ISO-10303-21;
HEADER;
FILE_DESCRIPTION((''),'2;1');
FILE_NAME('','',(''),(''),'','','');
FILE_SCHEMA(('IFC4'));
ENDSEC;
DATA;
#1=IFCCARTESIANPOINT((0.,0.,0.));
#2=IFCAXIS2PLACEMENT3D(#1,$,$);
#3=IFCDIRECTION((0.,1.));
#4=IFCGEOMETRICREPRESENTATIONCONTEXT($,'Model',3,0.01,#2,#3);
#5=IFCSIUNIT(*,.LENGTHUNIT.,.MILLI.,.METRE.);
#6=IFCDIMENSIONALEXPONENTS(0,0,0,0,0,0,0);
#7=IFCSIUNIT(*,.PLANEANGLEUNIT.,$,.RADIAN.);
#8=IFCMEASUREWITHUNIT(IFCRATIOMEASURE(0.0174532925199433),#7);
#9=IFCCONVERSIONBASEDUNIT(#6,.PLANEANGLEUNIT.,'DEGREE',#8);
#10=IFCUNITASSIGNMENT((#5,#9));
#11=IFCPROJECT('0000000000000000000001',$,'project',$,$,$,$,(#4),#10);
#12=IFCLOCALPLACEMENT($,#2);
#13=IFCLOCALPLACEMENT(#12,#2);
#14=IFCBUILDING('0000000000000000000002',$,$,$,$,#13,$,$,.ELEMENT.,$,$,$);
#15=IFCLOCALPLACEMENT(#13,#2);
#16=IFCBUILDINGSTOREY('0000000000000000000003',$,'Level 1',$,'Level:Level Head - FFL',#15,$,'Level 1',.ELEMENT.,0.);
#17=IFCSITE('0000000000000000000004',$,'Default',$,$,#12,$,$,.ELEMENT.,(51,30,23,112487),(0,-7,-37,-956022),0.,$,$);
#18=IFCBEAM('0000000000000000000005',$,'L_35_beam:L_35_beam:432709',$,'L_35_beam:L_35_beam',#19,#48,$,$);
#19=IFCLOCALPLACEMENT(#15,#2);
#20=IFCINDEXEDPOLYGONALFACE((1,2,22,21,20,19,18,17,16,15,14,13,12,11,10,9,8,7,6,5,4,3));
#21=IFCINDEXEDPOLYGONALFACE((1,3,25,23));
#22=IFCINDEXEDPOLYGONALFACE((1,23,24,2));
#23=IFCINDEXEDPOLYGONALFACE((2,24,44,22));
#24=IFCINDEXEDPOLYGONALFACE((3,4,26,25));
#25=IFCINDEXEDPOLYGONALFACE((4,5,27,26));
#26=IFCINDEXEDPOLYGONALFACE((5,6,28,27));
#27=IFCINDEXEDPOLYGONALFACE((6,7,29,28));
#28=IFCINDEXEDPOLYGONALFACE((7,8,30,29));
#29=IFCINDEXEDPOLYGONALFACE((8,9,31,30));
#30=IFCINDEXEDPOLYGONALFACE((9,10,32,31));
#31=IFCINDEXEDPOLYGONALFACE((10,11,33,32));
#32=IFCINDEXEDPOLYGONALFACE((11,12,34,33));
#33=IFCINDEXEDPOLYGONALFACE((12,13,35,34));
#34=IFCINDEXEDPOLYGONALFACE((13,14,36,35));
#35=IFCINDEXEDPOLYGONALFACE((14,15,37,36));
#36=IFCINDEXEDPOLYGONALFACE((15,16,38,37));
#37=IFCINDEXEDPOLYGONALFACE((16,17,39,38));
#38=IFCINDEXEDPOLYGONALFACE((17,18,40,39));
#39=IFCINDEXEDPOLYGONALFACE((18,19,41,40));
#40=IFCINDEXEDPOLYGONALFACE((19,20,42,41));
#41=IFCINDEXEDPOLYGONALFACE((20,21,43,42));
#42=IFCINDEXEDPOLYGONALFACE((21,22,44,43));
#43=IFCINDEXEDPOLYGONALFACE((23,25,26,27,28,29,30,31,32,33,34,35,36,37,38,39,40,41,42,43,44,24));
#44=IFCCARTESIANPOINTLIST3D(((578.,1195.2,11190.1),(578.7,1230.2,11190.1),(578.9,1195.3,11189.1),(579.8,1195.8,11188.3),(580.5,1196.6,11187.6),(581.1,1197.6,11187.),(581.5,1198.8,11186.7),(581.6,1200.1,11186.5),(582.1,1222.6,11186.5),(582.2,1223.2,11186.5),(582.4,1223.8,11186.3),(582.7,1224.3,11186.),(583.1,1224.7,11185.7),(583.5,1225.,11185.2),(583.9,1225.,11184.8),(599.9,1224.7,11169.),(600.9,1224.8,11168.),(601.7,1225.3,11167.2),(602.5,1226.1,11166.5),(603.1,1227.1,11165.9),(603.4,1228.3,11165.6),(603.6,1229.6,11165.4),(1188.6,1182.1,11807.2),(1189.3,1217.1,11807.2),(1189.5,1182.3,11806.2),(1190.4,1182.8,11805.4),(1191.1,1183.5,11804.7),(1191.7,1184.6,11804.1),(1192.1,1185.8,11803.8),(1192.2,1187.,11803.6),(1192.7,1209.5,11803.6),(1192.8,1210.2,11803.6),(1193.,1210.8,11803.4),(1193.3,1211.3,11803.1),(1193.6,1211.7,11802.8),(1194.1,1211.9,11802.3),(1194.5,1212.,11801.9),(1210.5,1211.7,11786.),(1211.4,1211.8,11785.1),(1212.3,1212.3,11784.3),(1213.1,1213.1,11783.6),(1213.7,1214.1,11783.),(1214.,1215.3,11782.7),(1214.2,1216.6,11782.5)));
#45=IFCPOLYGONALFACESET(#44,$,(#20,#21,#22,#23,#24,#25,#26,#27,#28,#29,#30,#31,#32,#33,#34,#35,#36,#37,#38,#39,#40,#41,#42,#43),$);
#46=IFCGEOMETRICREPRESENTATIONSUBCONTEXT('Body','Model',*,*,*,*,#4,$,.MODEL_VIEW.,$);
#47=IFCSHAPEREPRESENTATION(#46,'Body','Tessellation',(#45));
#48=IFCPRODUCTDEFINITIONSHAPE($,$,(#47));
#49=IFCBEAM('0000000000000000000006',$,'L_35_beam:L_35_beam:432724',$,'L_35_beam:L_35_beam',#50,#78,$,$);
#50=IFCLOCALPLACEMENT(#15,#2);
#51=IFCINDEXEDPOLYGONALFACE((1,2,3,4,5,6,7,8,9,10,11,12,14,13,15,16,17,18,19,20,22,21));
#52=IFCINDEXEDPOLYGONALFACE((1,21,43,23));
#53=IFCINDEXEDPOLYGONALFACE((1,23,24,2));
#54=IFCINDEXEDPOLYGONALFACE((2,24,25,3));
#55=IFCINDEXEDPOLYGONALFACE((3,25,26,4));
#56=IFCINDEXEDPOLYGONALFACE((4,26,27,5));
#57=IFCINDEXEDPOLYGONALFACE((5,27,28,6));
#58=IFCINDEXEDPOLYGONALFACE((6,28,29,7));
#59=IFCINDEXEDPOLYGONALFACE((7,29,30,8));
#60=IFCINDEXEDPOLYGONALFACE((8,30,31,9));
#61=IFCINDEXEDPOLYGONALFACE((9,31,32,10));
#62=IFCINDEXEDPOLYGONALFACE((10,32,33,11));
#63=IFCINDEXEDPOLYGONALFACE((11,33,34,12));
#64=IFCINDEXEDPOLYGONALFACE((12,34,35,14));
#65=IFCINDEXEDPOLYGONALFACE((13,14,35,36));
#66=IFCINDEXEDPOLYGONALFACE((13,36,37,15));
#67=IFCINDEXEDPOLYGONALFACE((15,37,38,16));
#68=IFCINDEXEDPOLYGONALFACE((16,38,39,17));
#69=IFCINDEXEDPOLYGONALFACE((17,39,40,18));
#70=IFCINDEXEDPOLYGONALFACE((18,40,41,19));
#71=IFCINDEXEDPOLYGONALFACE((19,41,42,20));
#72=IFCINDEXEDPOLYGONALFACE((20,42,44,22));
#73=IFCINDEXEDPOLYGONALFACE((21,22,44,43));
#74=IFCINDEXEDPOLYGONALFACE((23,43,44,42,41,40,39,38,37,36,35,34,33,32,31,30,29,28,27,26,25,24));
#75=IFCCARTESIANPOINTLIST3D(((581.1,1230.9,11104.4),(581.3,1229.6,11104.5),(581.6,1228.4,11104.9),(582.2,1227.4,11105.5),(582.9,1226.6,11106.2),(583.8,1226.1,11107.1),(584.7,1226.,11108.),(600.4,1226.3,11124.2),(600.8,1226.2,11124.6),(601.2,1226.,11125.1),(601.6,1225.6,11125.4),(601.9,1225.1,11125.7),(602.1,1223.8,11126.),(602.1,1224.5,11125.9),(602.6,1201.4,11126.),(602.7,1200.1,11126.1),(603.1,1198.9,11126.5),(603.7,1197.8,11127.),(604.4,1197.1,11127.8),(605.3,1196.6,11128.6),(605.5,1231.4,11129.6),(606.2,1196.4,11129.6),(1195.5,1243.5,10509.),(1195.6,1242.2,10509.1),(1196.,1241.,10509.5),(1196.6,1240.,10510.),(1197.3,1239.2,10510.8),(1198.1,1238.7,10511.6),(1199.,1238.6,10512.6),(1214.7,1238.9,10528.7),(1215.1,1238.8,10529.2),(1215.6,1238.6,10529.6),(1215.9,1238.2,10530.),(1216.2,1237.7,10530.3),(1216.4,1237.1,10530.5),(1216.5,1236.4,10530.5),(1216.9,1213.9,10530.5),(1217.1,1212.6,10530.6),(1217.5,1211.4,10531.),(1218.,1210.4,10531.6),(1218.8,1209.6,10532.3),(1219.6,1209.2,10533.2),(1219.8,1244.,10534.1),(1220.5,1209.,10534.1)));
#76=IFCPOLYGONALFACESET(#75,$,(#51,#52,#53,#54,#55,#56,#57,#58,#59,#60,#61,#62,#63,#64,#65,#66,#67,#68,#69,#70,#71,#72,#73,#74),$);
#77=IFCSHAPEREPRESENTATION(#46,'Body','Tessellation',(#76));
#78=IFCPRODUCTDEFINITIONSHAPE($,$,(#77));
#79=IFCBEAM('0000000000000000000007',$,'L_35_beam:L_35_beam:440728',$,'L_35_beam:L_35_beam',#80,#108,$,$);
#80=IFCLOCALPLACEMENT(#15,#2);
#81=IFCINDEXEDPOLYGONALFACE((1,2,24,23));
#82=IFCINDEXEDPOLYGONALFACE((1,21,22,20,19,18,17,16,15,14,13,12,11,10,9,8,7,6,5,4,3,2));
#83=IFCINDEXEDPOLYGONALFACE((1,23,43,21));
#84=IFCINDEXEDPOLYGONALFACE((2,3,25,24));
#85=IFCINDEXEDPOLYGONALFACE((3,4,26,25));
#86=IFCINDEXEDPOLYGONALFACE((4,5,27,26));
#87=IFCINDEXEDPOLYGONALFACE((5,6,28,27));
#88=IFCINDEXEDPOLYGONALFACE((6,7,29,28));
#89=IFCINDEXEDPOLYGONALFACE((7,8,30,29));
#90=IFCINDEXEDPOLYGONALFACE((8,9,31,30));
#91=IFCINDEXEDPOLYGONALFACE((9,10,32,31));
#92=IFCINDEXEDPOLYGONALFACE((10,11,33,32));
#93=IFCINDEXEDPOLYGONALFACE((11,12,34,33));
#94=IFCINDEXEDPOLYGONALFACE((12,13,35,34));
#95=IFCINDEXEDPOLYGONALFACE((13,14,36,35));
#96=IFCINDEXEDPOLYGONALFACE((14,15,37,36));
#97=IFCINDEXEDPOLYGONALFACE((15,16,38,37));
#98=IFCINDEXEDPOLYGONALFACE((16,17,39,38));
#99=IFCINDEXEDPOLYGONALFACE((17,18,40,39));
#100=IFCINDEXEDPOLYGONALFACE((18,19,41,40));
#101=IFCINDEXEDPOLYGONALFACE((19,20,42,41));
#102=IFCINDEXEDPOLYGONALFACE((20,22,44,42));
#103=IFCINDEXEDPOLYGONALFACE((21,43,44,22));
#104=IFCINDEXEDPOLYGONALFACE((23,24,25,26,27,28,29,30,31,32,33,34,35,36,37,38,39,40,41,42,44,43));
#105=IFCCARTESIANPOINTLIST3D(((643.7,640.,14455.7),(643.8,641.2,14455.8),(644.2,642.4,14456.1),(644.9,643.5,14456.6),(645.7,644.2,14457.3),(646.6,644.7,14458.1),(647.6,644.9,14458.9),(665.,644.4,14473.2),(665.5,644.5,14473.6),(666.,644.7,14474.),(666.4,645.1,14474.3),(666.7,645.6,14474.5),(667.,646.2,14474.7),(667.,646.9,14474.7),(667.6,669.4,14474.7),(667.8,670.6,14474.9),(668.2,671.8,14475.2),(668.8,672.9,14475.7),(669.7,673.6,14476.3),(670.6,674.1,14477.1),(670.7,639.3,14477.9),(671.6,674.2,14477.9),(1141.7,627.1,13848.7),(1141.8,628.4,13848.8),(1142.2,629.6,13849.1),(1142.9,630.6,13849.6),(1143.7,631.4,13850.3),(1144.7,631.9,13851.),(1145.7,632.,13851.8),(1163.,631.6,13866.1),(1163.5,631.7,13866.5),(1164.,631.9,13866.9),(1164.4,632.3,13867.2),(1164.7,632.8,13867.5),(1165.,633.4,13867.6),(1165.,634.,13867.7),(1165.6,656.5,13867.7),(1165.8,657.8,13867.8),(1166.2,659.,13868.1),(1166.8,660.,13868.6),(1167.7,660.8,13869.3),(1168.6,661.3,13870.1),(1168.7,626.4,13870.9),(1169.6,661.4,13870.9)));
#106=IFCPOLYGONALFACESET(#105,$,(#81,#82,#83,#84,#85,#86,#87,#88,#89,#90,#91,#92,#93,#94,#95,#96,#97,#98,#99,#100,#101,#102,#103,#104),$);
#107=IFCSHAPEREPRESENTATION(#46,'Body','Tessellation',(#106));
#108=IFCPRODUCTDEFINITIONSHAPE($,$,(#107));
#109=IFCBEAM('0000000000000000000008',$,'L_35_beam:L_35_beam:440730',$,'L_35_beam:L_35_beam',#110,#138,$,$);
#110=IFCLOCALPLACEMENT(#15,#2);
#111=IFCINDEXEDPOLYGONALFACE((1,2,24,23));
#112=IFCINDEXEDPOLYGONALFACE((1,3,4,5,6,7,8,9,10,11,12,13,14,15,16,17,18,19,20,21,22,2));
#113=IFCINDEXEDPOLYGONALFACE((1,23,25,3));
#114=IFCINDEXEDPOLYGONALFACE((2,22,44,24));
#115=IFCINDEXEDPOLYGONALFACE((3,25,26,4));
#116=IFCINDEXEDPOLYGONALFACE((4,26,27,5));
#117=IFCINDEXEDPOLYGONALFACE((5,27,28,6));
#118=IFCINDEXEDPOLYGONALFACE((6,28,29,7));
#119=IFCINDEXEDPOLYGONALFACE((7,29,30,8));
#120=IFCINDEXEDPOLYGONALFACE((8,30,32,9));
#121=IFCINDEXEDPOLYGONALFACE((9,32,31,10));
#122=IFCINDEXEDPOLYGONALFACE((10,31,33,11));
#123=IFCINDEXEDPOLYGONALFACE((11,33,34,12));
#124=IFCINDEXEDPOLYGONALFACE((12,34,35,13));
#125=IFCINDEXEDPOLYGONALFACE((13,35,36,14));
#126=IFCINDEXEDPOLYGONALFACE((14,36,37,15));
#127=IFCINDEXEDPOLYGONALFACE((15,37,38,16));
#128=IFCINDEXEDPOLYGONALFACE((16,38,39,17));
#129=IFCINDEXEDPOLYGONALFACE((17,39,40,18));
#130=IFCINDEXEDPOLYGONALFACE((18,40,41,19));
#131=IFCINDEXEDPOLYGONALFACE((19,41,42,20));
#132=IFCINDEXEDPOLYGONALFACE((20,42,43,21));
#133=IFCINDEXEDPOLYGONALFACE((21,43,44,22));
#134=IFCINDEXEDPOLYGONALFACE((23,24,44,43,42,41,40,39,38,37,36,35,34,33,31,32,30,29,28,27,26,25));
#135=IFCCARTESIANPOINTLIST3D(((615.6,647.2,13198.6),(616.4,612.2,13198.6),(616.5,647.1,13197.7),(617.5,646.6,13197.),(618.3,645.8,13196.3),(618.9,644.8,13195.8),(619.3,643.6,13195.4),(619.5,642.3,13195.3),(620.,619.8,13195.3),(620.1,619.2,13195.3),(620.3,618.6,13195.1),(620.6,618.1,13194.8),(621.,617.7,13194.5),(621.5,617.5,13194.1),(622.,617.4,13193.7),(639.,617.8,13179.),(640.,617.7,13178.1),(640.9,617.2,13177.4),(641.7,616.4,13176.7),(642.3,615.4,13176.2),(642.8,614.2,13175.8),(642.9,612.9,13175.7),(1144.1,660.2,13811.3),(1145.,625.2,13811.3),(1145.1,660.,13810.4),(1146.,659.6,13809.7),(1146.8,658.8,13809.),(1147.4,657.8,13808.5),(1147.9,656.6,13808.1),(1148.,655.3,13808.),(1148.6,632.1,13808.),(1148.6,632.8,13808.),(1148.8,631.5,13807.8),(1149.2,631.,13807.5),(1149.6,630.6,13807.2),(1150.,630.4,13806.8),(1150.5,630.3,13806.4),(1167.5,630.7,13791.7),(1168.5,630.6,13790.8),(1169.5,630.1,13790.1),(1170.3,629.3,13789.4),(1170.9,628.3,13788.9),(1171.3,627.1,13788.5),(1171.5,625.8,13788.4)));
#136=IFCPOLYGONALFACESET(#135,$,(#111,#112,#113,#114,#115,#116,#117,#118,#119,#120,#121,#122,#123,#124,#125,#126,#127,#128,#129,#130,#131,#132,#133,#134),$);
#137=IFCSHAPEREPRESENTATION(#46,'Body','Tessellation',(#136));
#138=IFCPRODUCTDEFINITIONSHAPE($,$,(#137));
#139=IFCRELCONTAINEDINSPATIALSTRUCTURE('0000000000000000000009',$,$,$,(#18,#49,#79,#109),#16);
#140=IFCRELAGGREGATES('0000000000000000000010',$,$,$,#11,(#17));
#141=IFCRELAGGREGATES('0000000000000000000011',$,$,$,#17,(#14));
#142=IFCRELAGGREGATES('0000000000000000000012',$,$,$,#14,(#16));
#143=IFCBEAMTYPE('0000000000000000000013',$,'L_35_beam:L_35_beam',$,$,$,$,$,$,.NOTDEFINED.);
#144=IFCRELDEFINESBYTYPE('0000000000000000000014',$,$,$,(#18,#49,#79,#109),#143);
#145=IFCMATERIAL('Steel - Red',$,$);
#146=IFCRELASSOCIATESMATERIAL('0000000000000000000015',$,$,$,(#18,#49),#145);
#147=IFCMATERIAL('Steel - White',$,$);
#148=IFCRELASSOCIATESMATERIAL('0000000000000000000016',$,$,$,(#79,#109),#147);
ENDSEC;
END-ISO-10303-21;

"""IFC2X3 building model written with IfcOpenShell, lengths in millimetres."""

from ifc_helpers import new_model, entity, si_unit, converted_unit, direction, frame, frame_2d, origin, place, context, subcontext, project, spatial, polyline, circle_curve, parameter, trimmed, segment, composite_curve, outline, extrude, material, type_object, element, save


model = new_model("IFC2X3")

# Units and contexts
model_context = context("Model", 3, precision=0.01, world=origin(), true_north=direction((0.0, 1.0)))
body_context = subcontext(model_context, "Body", "Model", "MODEL_VIEW")
ifc_project = project(units=[si_unit("LENGTHUNIT", "METRE", prefix="MILLI"), converted_unit("PLANEANGLEUNIT", "DEGREE", entity("IfcRatioMeasure", 0.0174532925199433), si_unit("PLANEANGLEUNIT", "RADIAN"), dimensions=[0, 0, 0, 0, 0, 0, 0])], contexts=[model_context])

# Site, building, storey
site_placement = place(None, origin())
site = spatial("IfcSite", under=ifc_project, at=site_placement, Name="Default", CompositionType="ELEMENT", RefLatitude=(51, 30, 23, 112487), RefLongitude=(0, -7, -37, -956022), RefElevation=0.0)
building_placement = place(site_placement, origin())
building = spatial("IfcBuilding", under=site, at=building_placement, CompositionType="ELEMENT")
storey_placement = place(building_placement, origin())
storey = spatial("IfcBuildingStorey", under=building, at=storey_placement, Name="Level 1", ObjectType="Level:Level Head - FFL", LongName="Level 1", CompositionType="ELEMENT", Elevation=0.0)

# Beams
ifc_material_1 = material(Name="Steel - Red")
ifc_material_2 = material(Name="Steel - White")
beam_type_1 = type_object("IfcBeamType", Name="L_35_beam:L_35_beam", PredefinedType="NOTDEFINED")
beam_1_placement = place(storey_placement, frame((561.5, 1238.5, 11147.6), z_axis=(0.710924, 0.014856, -0.703112), x_axis=(0.703269, -0.015018, 0.710765)))
element("IfcBeam", 1, at=beam_1_placement, inside=storey, type_object=beam_type_1, material=ifc_material_1, Name="L_35_beam:L_35_beam:432709", ObjectType="L_35_beam:L_35_beam", context=body_context, shape_type="SweptSolid", body=[
    extrude(outline(composite_curve([segment(polyline([(-4.3, 6.8), (18.2, 6.8)]), True, "CONTINUOUS"), segment(trimmed(circle_curve(frame_2d((18.2, 11.8), x_axis=(0.0, -1.0)), 5.0), [parameter(0.0)], [parameter(90.0)], True, "PARAMETER"), True, "CONTINUOUS"), segment(polyline([(23.2, 11.8), (-11.8, 11.8)]), True, "CONTINUOUS"), segment(polyline([(-11.8, 11.8), (-11.8, -23.2)]), True, "CONTINUOUS"), segment(trimmed(circle_curve(frame_2d((-11.8, -18.2), x_axis=(0.0, -1.0)), 5.0), [parameter(0.0)], [parameter(90.0)], True, "PARAMETER"), True, "CONTINUOUS"), segment(polyline([(-6.8, -18.2), (-6.8, 4.3)]), True, "CONTINUOUS"), segment(trimmed(circle_curve(frame_2d((-4.3, 4.3), x_axis=(-1.0, 0.0)), 2.5), [parameter(270.0)], [parameter(0.0)], True, "PARAMETER"), False, "CONTINUOUS")], self_intersect=False)), frame((42.4, 19.6, -6.3), z_axis=(1.0, 0.0, 0.0), x_axis=(0.0, 0.030031, 0.999549)), (0.0, 0.0, 1.0), 868.2),
])
beam_2_placement = place(storey_placement, frame((561.5, 1238.5, 11147.6), z_axis=(0.695761, 0.014249, 0.718132), x_axis=(0.717982, 0.014704, -0.695907)))
element("IfcBeam", 2, at=beam_2_placement, inside=storey, type_object=beam_type_1, material=ifc_material_1, Name="L_35_beam:L_35_beam:432724", ObjectType="L_35_beam:L_35_beam", context=body_context, shape_type="SweptSolid", body=[
    extrude(outline(composite_curve([segment(polyline([(-23.2, -11.8), (11.8, -11.8)]), True, "CONTINUOUS"), segment(polyline([(11.8, -11.8), (11.8, 23.2)]), True, "CONTINUOUS"), segment(trimmed(circle_curve(frame_2d((11.8, 18.2), x_axis=(0.0, 1.0)), 5.0), [parameter(0.0)], [parameter(90.0)], True, "PARAMETER"), True, "CONTINUOUS"), segment(polyline([(6.8, 18.2), (6.8, -4.3)]), True, "CONTINUOUS"), segment(trimmed(circle_curve(frame_2d((4.3, -4.3), x_axis=(1.0, 0.0)), 2.5), [parameter(270.0)], [parameter(0.0)], True, "PARAMETER"), False, "CONTINUOUS"), segment(polyline([(4.3, -6.8), (-18.2, -6.8)]), True, "CONTINUOUS"), segment(trimmed(circle_curve(frame_2d((-18.2, -11.8), x_axis=(0.0, 1.0)), 5.0), [parameter(0.0)], [parameter(90.0)], True, "PARAMETER"), True, "CONTINUOUS")], self_intersect=False)), frame((44.0, -19.8, 5.7), z_axis=(1.0, 0.0, 0.0), x_axis=(0.0, 0.0, 1.0)), (0.0, 0.0, 1.0), 855.7),
])
beam_3_placement = place(storey_placement, frame((1181.8, 618.1, 13827.0), z_axis=(0.773193, 0.013397, 0.634029), x_axis=(-0.63417, 0.016334, 0.773021)))
element("IfcBeam", 3, at=beam_3_placement, inside=storey, type_object=beam_type_1, material=ifc_material_2, Name="L_35_beam:L_35_beam:440728", ObjectType="L_35_beam:L_35_beam", context=body_context, shape_type="SweptSolid", body=[
    extrude(outline(composite_curve([segment(polyline([(-23.2, -11.8), (11.8, -11.8)]), True, "CONTINUOUS"), segment(polyline([(11.8, -11.8), (11.8, 23.2)]), True, "CONTINUOUS"), segment(trimmed(circle_curve(frame_2d((11.8, 18.2), x_axis=(0.0, 1.0)), 5.0), [parameter(0.0)], [parameter(90.0)], True, "PARAMETER"), True, "CONTINUOUS"), segment(polyline([(6.8, 18.2), (6.8, -4.3)]), True, "CONTINUOUS"), segment(trimmed(circle_curve(frame_2d((4.3, -4.3), x_axis=(1.0, 0.0)), 2.5), [parameter(270.0)], [parameter(0.0)], True, "PARAMETER"), False, "CONTINUOUS"), segment(polyline([(4.3, -6.8), (-18.2, -6.8)]), True, "CONTINUOUS"), segment(trimmed(circle_curve(frame_2d((-18.2, -11.8), x_axis=(0.0, 1.0)), 5.0), [parameter(0.0)], [parameter(90.0)], True, "PARAMETER"), True, "CONTINUOUS")], self_intersect=False)), frame((42.4, -19.6, 6.4), z_axis=(1.0, 0.0, 0.0), x_axis=(0.0, 0.0333, 0.999445)), (0.0, 0.0, 1.0), 785.3),
])
beam_4_placement = place(storey_placement, frame((1181.8, 618.1, 13827.0), z_axis=(0.757265, -0.013797, -0.652962), x_axis=(-0.653107, -0.015997, -0.757096)))
element("IfcBeam", 4, at=beam_4_placement, inside=storey, type_object=beam_type_1, material=ifc_material_2, Name="L_35_beam:L_35_beam:440730", ObjectType="L_35_beam:L_35_beam", context=body_context, shape_type="SweptSolid", body=[
    extrude(outline(composite_curve([segment(polyline([(-4.3, 6.8), (18.2, 6.8)]), True, "CONTINUOUS"), segment(trimmed(circle_curve(frame_2d((18.2, 11.8), x_axis=(0.0, -1.0)), 5.0), [parameter(0.0)], [parameter(90.0)], True, "PARAMETER"), True, "CONTINUOUS"), segment(polyline([(23.2, 11.8), (-11.8, 11.8)]), True, "CONTINUOUS"), segment(polyline([(-11.8, 11.8), (-11.8, -23.2)]), True, "CONTINUOUS"), segment(trimmed(circle_curve(frame_2d((-11.8, -18.2), x_axis=(0.0, -1.0)), 5.0), [parameter(0.0)], [parameter(90.0)], True, "PARAMETER"), True, "CONTINUOUS"), segment(polyline([(-6.8, -18.2), (-6.8, 4.3)]), True, "CONTINUOUS"), segment(trimmed(circle_curve(frame_2d((-4.3, 4.3), x_axis=(-1.0, 0.0)), 2.5), [parameter(270.0)], [parameter(0.0)], True, "PARAMETER"), False, "CONTINUOUS")], self_intersect=False)), frame((35.9, 19.6, -6.4), z_axis=(1.0, 0.0, 0.0), x_axis=(0.0, 0.032335, 0.999477)), (0.0, 0.0, 1.0), 809.3),
])

save(model, "model.ifc")
